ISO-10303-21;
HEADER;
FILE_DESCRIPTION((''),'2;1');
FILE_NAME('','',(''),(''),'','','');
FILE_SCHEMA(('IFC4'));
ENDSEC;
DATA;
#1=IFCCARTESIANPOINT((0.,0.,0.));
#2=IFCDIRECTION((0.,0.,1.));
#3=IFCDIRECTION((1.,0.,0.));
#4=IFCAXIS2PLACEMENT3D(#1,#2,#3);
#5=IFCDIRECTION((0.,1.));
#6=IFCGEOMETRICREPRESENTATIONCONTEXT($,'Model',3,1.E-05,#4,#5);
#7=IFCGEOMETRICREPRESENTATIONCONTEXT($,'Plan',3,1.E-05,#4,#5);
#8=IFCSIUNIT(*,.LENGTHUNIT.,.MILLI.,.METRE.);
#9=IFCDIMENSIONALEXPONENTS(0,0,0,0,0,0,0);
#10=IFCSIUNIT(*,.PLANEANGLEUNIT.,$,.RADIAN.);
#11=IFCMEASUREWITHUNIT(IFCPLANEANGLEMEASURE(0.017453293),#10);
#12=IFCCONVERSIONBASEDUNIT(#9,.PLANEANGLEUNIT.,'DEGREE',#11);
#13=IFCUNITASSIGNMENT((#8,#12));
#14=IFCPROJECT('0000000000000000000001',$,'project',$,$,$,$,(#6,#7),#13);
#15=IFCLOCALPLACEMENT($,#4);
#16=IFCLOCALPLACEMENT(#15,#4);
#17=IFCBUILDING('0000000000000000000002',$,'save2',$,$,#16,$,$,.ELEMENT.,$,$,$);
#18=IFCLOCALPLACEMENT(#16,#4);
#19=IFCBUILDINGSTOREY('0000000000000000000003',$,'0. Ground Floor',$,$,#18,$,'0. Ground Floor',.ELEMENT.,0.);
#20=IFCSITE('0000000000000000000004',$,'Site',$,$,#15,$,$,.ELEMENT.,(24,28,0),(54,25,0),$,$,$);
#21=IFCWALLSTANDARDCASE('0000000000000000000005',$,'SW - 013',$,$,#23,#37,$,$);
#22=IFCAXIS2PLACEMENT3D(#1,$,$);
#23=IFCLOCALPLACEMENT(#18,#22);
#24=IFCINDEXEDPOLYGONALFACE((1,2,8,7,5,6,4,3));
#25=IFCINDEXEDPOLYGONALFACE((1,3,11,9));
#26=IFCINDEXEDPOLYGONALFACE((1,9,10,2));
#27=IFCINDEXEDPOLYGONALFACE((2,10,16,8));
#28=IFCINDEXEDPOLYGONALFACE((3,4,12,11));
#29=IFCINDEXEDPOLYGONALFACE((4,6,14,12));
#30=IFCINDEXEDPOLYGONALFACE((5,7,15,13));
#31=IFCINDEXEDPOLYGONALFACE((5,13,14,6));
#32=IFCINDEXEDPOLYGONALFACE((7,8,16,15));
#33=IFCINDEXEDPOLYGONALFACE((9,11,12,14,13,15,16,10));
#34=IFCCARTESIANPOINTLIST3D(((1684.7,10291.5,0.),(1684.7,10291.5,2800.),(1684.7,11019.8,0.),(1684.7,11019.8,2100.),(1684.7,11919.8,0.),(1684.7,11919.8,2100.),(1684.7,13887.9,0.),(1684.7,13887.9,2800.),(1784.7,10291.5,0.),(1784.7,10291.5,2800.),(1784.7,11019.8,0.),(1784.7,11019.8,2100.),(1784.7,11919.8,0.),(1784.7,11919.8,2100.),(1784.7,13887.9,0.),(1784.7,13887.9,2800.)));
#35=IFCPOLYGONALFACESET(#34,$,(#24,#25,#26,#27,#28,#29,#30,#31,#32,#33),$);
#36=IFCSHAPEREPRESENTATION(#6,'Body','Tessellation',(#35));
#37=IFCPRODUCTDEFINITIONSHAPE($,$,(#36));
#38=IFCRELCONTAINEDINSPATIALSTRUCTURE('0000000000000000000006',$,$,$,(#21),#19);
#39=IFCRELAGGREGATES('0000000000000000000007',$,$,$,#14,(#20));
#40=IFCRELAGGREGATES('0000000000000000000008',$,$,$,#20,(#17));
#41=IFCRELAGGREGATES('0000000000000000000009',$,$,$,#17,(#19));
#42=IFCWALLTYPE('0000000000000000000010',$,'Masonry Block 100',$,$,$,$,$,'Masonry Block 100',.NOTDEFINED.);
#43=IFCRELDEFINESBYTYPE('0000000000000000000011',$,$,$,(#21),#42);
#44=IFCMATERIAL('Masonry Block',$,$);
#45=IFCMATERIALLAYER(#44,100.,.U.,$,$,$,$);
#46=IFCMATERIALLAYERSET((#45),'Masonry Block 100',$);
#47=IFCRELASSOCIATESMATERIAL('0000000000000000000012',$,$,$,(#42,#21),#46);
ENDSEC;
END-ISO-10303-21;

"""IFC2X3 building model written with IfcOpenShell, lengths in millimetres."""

from ifc_helpers import new_model, entity, si_unit, converted_unit, direction, frame, frame_2d, origin_with_axes, place, context, project, spatial, polyline, rectangle, outline, extrude, material, layer, layer_set, layer_usage, type_object, element, save


model = new_model("IFC2X3")

# Units and contexts
model_context = context("Model", 3, precision=1e-05, world=origin_with_axes(), true_north=direction((0.0, 1.0)))
plan_context = context("Plan", 3, precision=1e-05, world=origin_with_axes(), true_north=direction((0.0, 1.0)))
ifc_project = project(units=[si_unit("LENGTHUNIT", "METRE", prefix="MILLI"), converted_unit("PLANEANGLEUNIT", "DEGREE", entity("IfcPlaneAngleMeasure", 0.017453293), si_unit("PLANEANGLEUNIT", "RADIAN"), dimensions=[0, 0, 0, 0, 0, 0, 0])], contexts=[model_context, plan_context])

# Site, building, storey
site_placement = place(None, origin_with_axes())
site = spatial("IfcSite", under=ifc_project, at=site_placement, Name="Site", CompositionType="ELEMENT", RefLatitude=(24, 28, 0), RefLongitude=(54, 25, 0))
building_placement = place(site_placement, origin_with_axes())
building = spatial("IfcBuilding", under=site, at=building_placement, Name="save2", CompositionType="ELEMENT")
storey_placement = place(building_placement, origin_with_axes())
storey = spatial("IfcBuildingStorey", under=building, at=storey_placement, Name="0. Ground Floor", LongName="0. Ground Floor", CompositionType="ELEMENT", Elevation=0.0)

# Wall, opening
ifc_material_1 = material(Name="Masonry Block")
ifc_layer_1 = layer(ifc_material_1, 100.0, ventilated="UNKNOWN")
ifc_layer_set_1 = layer_set([ifc_layer_1], Name="Masonry Block 100")
ifc_layer_usage_1 = layer_usage(ifc_layer_set_1, "AXIS2", "POSITIVE", 0.0)
wall_type_1 = type_object("IfcWallType", Name="Masonry Block 100", ElementType="Masonry Block 100", PredefinedType="NOTDEFINED", material=ifc_layer_set_1)
wall_1_placement = place(storey_placement, frame((1684.7, 13887.9, 0.0), z_axis=(0.0, 0.0, 1.0), x_axis=(0.0, -1.0, 0.0)))
wall_1 = element("IfcWallStandardCase", 1, at=wall_1_placement, inside=storey, type_object=wall_type_1, material=ifc_layer_usage_1, Name="SW - 013", context=model_context, shape_type="SweptSolid", body=[
    extrude(outline(polyline([(0.0, 0.0), (3596.4, 0.0), (3596.4, 100.0), (0.0, 100.0), (0.0, 0.0)])), origin_with_axes(), (0.0, 0.0, 1.0), 2800.0),
])
opening_1_placement = place(wall_1_placement, frame((2418.1, 0.0, 0.0), z_axis=(0.0, 0.0, 1.0), x_axis=(1.0, 0.0, 0.0)))
element("IfcOpeningElement", 2, at=opening_1_placement, cuts=wall_1, ObjectType="Opening", context=model_context, shape_type="SweptSolid", body=[
    extrude(rectangle(XDim=900.0, YDim=2100.0, at=frame_2d((0.0, 1050.0), x_axis=(-1.0, 0.0))), frame((0.0, 0.0, 0.0), z_axis=(0.0, 1.0, 0.0), x_axis=(-1.0, 0.0, 0.0)), (0.0, 0.0, 1.0), 100.0),
])

save(model, "model.ifc")
